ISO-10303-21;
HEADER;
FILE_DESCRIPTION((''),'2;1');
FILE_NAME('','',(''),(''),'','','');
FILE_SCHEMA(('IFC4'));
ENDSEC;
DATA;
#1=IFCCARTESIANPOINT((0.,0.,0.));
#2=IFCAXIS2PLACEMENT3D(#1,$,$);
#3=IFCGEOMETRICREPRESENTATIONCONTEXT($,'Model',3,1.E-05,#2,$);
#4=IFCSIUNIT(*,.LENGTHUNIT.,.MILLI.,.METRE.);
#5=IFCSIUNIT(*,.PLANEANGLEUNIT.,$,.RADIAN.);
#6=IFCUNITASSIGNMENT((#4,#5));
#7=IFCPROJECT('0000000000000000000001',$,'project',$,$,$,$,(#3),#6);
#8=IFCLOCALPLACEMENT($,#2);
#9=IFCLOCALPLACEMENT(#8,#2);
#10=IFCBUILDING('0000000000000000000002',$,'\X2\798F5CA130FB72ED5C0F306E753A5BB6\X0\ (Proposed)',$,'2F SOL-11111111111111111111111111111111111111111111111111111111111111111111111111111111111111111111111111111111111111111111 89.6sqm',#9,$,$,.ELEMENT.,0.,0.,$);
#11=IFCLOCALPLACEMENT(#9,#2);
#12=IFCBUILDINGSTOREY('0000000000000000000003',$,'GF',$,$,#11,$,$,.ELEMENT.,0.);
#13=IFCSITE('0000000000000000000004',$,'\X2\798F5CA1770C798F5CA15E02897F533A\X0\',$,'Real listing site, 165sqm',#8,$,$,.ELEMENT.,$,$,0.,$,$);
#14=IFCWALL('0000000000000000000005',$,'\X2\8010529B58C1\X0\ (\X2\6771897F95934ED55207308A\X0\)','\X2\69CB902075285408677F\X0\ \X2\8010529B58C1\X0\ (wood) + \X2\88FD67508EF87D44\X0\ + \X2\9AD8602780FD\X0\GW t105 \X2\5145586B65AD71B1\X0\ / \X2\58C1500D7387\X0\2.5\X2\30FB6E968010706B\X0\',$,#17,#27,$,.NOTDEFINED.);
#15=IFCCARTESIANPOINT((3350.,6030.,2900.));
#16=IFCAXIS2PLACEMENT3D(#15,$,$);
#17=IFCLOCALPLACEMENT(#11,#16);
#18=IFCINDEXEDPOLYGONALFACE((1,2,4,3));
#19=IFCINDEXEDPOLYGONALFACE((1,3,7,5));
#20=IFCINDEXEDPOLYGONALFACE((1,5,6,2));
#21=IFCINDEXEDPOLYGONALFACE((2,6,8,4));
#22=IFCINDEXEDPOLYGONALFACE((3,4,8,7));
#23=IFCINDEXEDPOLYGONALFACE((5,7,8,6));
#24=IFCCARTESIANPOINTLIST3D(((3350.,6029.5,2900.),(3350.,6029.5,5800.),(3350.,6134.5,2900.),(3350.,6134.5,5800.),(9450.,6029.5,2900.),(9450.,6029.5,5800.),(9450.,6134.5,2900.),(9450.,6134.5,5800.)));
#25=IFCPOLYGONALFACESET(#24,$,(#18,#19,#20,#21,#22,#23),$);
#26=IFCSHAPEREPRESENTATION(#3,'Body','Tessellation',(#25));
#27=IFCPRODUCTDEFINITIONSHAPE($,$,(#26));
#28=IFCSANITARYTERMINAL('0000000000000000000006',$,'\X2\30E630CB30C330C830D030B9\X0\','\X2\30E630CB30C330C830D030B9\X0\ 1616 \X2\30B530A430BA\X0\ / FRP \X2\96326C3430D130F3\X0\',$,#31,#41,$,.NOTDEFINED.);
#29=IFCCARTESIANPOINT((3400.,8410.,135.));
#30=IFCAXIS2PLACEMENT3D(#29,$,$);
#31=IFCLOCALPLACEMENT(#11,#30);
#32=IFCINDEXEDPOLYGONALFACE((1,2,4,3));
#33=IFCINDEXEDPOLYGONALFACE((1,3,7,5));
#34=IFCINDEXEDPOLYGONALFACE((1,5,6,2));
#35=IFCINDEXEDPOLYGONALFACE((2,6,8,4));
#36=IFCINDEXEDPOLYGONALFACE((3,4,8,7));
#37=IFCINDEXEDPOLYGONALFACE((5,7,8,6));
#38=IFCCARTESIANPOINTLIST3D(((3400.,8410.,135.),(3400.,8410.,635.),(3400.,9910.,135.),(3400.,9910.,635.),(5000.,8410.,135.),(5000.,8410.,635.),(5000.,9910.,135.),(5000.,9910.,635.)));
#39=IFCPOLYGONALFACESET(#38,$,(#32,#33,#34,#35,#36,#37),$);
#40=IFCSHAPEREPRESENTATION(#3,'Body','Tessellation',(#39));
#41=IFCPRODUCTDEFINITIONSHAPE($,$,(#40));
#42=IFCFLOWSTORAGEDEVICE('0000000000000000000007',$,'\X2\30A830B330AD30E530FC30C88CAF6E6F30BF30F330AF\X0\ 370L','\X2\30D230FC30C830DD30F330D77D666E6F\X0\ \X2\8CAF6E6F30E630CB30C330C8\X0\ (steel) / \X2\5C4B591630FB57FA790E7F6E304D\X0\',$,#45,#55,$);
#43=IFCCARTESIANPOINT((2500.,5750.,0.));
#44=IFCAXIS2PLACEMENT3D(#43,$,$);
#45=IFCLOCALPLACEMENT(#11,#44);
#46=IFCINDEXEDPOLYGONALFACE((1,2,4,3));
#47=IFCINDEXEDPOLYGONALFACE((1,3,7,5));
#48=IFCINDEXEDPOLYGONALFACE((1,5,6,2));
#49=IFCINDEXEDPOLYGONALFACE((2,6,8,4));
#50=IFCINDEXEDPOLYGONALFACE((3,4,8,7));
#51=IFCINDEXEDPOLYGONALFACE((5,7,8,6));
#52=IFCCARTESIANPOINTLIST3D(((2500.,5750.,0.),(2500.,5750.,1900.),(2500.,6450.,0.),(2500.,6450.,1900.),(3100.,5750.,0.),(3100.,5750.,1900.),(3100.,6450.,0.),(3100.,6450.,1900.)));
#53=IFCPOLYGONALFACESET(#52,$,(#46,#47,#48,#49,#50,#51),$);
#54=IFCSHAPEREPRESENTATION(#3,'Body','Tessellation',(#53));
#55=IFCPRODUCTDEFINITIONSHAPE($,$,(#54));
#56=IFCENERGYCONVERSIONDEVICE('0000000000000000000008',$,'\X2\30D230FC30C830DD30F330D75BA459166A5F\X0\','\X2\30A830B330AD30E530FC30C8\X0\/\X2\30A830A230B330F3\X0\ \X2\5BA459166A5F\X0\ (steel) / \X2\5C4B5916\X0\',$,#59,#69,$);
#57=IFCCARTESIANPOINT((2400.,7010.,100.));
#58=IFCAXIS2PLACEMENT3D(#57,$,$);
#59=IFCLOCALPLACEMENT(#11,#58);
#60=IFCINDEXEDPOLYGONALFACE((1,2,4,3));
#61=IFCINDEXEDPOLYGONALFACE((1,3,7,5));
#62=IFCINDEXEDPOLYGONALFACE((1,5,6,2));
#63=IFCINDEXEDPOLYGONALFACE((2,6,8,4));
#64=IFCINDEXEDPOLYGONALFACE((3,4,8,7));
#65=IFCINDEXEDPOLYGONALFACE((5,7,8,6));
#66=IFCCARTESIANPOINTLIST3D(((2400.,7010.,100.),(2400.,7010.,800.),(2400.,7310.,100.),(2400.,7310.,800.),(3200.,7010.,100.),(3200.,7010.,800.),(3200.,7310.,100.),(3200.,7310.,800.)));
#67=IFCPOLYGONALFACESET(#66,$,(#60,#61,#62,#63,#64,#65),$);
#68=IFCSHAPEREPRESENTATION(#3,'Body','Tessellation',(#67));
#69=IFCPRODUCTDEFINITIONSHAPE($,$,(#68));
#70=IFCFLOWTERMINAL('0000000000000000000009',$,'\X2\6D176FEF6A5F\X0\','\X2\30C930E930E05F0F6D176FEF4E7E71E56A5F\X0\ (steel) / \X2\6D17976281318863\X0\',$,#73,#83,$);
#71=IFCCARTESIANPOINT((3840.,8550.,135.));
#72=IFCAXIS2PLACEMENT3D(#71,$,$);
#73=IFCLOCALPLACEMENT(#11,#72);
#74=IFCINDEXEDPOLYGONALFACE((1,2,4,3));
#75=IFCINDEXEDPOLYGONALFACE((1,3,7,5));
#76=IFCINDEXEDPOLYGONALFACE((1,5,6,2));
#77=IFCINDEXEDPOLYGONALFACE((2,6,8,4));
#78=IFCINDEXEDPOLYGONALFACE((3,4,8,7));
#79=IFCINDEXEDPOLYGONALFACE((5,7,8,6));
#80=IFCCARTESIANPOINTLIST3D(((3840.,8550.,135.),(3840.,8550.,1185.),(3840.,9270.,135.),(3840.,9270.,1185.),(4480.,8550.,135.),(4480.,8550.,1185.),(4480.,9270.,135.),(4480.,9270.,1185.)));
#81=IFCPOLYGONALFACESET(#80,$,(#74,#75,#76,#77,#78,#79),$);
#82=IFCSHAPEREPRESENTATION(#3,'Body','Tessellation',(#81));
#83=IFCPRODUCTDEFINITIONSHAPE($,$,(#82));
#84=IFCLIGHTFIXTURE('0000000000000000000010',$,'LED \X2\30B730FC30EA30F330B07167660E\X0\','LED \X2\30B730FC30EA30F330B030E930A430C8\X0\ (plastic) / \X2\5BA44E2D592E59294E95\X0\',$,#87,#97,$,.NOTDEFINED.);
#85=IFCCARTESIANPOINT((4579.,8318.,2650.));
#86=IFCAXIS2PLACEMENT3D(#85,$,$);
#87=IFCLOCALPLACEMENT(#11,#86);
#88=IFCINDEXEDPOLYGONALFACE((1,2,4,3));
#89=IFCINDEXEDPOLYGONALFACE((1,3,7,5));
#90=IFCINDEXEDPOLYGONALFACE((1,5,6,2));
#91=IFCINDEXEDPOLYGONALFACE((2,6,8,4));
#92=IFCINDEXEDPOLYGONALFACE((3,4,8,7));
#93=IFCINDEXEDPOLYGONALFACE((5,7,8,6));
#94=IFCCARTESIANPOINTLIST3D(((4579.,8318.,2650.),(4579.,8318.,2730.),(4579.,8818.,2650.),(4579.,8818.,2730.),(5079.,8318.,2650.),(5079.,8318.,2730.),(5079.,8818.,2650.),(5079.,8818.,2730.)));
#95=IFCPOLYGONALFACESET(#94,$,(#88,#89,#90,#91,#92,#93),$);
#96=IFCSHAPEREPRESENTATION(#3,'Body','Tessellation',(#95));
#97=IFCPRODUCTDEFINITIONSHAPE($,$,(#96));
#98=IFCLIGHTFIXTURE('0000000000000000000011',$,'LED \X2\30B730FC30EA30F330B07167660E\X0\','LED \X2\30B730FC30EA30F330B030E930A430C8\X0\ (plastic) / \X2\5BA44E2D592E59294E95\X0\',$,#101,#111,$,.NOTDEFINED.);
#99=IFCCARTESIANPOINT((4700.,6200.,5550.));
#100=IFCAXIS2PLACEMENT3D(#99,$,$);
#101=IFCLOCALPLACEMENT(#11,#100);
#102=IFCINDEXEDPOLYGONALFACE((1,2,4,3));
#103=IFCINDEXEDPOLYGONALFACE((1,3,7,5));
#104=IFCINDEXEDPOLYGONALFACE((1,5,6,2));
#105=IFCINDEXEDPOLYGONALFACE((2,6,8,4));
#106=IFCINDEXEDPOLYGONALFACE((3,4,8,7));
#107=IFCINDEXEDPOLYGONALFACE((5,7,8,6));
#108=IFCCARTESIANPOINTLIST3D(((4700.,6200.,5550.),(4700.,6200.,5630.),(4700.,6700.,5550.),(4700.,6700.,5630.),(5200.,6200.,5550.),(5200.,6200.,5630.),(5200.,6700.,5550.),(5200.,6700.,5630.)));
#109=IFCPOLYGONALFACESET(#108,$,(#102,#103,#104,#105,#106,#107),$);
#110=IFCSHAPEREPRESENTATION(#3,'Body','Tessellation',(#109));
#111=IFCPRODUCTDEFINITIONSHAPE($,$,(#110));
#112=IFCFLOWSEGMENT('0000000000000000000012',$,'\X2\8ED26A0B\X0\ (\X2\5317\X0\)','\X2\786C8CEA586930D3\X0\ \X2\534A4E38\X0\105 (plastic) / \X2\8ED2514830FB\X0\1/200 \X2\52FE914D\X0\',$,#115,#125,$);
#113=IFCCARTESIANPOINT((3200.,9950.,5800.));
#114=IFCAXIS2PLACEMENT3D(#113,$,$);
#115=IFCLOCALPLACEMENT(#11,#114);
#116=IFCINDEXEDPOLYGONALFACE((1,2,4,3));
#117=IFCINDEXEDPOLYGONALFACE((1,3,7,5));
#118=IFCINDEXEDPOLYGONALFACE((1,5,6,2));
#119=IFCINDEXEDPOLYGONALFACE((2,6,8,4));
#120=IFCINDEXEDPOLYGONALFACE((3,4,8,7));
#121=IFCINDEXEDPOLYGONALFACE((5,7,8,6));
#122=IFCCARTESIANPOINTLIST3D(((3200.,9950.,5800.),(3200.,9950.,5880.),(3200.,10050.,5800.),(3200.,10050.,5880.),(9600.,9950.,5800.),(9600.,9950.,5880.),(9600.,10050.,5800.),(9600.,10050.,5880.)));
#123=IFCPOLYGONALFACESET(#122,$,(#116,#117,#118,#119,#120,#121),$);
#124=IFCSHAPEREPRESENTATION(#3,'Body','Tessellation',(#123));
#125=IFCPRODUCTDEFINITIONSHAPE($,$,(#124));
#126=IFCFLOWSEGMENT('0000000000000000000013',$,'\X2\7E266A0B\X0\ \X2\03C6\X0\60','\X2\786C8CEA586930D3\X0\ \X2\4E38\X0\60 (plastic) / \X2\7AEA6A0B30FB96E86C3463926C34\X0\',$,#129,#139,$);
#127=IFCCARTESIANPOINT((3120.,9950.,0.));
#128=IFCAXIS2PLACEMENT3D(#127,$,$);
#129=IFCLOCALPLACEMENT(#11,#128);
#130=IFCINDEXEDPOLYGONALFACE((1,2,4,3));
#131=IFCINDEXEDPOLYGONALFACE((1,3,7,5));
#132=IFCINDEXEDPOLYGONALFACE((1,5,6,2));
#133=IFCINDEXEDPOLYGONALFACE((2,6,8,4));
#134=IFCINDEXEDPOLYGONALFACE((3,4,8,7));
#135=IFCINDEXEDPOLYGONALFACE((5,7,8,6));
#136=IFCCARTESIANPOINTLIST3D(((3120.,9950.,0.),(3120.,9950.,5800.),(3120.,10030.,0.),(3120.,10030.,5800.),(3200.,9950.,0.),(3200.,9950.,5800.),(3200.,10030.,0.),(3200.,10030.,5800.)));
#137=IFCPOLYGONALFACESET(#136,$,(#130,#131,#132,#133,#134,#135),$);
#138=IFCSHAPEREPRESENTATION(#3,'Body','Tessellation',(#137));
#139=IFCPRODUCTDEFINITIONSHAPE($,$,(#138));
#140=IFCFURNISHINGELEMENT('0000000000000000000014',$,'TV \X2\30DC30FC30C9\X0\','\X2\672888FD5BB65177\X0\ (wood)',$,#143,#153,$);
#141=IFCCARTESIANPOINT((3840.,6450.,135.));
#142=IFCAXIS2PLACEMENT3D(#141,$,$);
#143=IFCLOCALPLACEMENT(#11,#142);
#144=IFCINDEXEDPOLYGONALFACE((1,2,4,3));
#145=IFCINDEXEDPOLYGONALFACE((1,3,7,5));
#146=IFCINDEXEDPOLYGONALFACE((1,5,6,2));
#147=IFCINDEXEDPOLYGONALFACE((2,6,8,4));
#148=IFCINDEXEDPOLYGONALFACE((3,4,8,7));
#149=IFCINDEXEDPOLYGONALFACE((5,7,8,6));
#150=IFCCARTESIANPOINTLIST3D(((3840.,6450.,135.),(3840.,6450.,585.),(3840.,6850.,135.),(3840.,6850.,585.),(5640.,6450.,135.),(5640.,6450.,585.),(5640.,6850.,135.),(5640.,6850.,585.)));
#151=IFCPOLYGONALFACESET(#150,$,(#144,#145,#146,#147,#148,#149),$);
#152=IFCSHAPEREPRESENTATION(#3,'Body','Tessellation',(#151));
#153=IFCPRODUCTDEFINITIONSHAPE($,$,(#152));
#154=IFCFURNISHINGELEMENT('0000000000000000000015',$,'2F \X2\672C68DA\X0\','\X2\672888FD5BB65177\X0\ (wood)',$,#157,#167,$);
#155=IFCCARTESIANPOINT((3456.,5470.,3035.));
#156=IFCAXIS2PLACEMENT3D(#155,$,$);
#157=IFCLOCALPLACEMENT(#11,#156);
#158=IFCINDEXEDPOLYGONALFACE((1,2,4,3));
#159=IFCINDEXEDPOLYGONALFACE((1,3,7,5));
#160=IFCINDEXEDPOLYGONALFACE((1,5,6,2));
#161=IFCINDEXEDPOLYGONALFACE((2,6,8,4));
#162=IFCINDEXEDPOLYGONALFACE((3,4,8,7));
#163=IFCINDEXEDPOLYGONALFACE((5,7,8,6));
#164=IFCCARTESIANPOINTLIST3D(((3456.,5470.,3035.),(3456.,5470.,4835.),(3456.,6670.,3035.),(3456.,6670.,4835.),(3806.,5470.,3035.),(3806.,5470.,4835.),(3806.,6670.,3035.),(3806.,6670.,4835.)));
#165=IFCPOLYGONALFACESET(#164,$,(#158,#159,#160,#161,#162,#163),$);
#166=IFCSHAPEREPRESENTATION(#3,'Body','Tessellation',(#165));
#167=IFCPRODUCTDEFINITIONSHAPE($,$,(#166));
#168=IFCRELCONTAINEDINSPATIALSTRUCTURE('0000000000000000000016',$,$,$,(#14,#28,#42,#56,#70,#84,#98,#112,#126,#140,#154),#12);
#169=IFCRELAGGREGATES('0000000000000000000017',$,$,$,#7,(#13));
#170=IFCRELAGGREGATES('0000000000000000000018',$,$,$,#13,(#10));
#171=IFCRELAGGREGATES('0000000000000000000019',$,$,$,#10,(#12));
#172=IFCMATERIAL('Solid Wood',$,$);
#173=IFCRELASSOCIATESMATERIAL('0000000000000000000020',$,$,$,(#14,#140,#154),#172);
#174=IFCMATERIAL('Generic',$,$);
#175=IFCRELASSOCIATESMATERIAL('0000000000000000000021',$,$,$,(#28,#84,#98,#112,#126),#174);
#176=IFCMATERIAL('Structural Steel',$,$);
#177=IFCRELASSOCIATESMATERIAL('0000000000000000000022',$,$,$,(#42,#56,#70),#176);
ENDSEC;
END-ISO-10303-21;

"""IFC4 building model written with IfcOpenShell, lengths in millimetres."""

from ifc_helpers import new_model, si_unit, frame, frame_2d, origin, place, context, project, spatial, rectangle, extrude, material, element, save


model = new_model("IFC4")

# Units and contexts
model_context = context("Model", 3, precision=1e-05, world=origin())
ifc_project = project(units=[si_unit("LENGTHUNIT", "METRE", prefix="MILLI"), si_unit("PLANEANGLEUNIT", "RADIAN")], contexts=[model_context])

# Site, building, storey
site_placement = place(None, origin())
site = spatial("IfcSite", under=ifc_project, at=site_placement, Name="福岡県福岡市西区", ObjectType="Real listing site, 165sqm", CompositionType="ELEMENT", RefElevation=0.0)
building_placement = place(site_placement, origin())
building = spatial("IfcBuilding", under=site, at=building_placement, Name="福岡・狭小の町家 (Proposed)", ObjectType="2F SOL-11111111111111111111111111111111111111111111111111111111111111111111111111111111111111111111111111111111111111111111 89.6sqm", CompositionType="ELEMENT", ElevationOfRefHeight=0.0, ElevationOfTerrain=0.0)
storey_placement = place(building_placement, origin())
storey = spatial("IfcBuildingStorey", under=building, at=storey_placement, Name="GF", CompositionType="ELEMENT", Elevation=0.0)

# Shared definitions
ifc_material_1 = material(Name="Solid Wood")

# Wall
wall_1_placement = place(storey_placement, frame((3350.0, 6030.0, 2900.0)))
element("IfcWall", 1, at=wall_1_placement, inside=storey, material=ifc_material_1, Name="耐力壁 (東西間仕切り)", Description="構造用合板 耐力壁 (wood) + 製材軸組 + 高性能GW t105 充填断熱 / 壁倍率2.5・準耐火", PredefinedType="NOTDEFINED", context=model_context, shape_type="SweptSolid", body=[
    extrude(rectangle(XDim=6100.0, YDim=105.0, at=frame_2d((3050.0, 52.0))), frame((3350.0, 6030.0, 2900.0)), (0.0, 0.0, 1.0), 2900.0),
])

# Sanitary terminal
ifc_material_2 = material(Name="Generic")
sanitary_terminal_placement = place(storey_placement, frame((3400.0, 8410.0, 135.0)))
element("IfcSanitaryTerminal", 2, at=sanitary_terminal_placement, inside=storey, material=ifc_material_2, Name="ユニットバス", Description="ユニットバス 1616 サイズ / FRP 防水パン", PredefinedType="NOTDEFINED", context=model_context, shape_type="SweptSolid", body=[
    extrude(rectangle(XDim=1600.0, YDim=1500.0, at=frame_2d((800.0, 750.0))), frame((3400.0, 8410.0, 135.0)), (0.0, 0.0, 1.0), 500.0),
])

# Flow storage device
ifc_material_3 = material(Name="Structural Steel")
flow_storage_device_placement = place(storey_placement, frame((2500.0, 5750.0, 0.0)))
element("IfcFlowStorageDevice", 3, at=flow_storage_device_placement, inside=storey, material=ifc_material_3, Name="エコキュート貯湯タンク 370L", Description="ヒートポンプ給湯 貯湯ユニット (steel) / 屋外・基礎置き", context=model_context, shape_type="SweptSolid", body=[
    extrude(rectangle(XDim=600.0, YDim=700.0, at=frame_2d((300.0, 350.0))), frame((2500.0, 5750.0, 0.0)), (0.0, 0.0, 1.0), 1900.0),
])

# Energy conversion device
energy_conversion_device_placement = place(storey_placement, frame((2400.0, 7010.0, 100.0)))
element("IfcEnergyConversionDevice", 4, at=energy_conversion_device_placement, inside=storey, material=ifc_material_3, Name="ヒートポンプ室外機", Description="エコキュート/エアコン 室外機 (steel) / 屋外", context=model_context, shape_type="SweptSolid", body=[
    extrude(rectangle(XDim=800.0, YDim=300.0, at=frame_2d((400.0, 150.0))), frame((2400.0, 7010.0, 100.0)), (0.0, 0.0, 1.0), 700.0),
])

# Flow terminal
flow_terminal_placement = place(storey_placement, frame((3840.0, 8550.0, 135.0)))
element("IfcFlowTerminal", 5, at=flow_terminal_placement, inside=storey, material=ifc_material_3, Name="洗濯機", Description="ドラム式洗濯乾燥機 (steel) / 洗面脱衣", context=model_context, shape_type="SweptSolid", body=[
    extrude(rectangle(XDim=640.0, YDim=720.0, at=frame_2d((320.0, 360.0))), frame((3840.0, 8550.0, 135.0)), (0.0, 0.0, 1.0), 1050.0),
])

# Light fixtures
light_fixture_1_placement = place(storey_placement, frame((4579.0, 8318.0, 2650.0)))
element("IfcLightFixture", 6, at=light_fixture_1_placement, inside=storey, material=ifc_material_2, Name="LED シーリング照明", Description="LED シーリングライト (plastic) / 室中央天井", PredefinedType="NOTDEFINED", context=model_context, shape_type="SweptSolid", body=[
    extrude(rectangle(XDim=500.0, YDim=500.0, at=frame_2d((250.0, 250.0))), frame((4579.0, 8318.0, 2650.0)), (0.0, 0.0, 1.0), 80.0),
])
light_fixture_2_placement = place(storey_placement, frame((4700.0, 6200.0, 5550.0)))
element("IfcLightFixture", 7, at=light_fixture_2_placement, inside=storey, material=ifc_material_2, Name="LED シーリング照明", Description="LED シーリングライト (plastic) / 室中央天井", PredefinedType="NOTDEFINED", context=model_context, shape_type="SweptSolid", body=[
    extrude(rectangle(XDim=500.0, YDim=500.0, at=frame_2d((250.0, 250.0))), frame((4700.0, 6200.0, 5550.0)), (0.0, 0.0, 1.0), 80.0),
])

# Flow segments
flow_segment_1_placement = place(storey_placement, frame((3200.0, 9950.0, 5800.0)))
element("IfcFlowSegment", 8, at=flow_segment_1_placement, inside=storey, material=ifc_material_2, Name="軒樋 (北)", Description="硬質塩ビ 半丸105 (plastic) / 軒先・1/200 勾配", context=model_context, shape_type="SweptSolid", body=[
    extrude(rectangle(XDim=6400.0, YDim=100.0, at=frame_2d((3200.0, 50.0))), frame((3200.0, 9950.0, 5800.0)), (0.0, 0.0, 1.0), 80.0),
])
flow_segment_2_placement = place(storey_placement, frame((3120.0, 9950.0, 0.0)))
element("IfcFlowSegment", 9, at=flow_segment_2_placement, inside=storey, material=ifc_material_2, Name="縦樋 φ60", Description="硬質塩ビ 丸60 (plastic) / 竪樋・雨水排水", context=model_context, shape_type="SweptSolid", body=[
    extrude(rectangle(XDim=80.0, YDim=80.0, at=frame_2d((40.0, 40.0))), frame((3120.0, 9950.0, 0.0)), (0.0, 0.0, 1.0), 5800.0),
])

# Furnishing elements
furnishing_1_placement = place(storey_placement, frame((3840.0, 6450.0, 135.0)))
element("IfcFurnishingElement", 10, at=furnishing_1_placement, inside=storey, material=ifc_material_1, Name="TV ボード", Description="木製家具 (wood)", context=model_context, shape_type="SweptSolid", body=[
    extrude(rectangle(XDim=1800.0, YDim=400.0, at=frame_2d((900.0, 200.0))), frame((3840.0, 6450.0, 135.0)), (0.0, 0.0, 1.0), 450.0),
])
furnishing_2_placement = place(storey_placement, frame((3456.0, 5470.0, 3035.0)))
element("IfcFurnishingElement", 11, at=furnishing_2_placement, inside=storey, material=ifc_material_1, Name="2F 本棚", Description="木製家具 (wood)", context=model_context, shape_type="SweptSolid", body=[
    extrude(rectangle(XDim=350.0, YDim=1200.0, at=frame_2d((175.0, 600.0))), frame((3456.0, 5470.0, 3035.0)), (0.0, 0.0, 1.0), 1800.0),
])

save(model, "model.ifc")
